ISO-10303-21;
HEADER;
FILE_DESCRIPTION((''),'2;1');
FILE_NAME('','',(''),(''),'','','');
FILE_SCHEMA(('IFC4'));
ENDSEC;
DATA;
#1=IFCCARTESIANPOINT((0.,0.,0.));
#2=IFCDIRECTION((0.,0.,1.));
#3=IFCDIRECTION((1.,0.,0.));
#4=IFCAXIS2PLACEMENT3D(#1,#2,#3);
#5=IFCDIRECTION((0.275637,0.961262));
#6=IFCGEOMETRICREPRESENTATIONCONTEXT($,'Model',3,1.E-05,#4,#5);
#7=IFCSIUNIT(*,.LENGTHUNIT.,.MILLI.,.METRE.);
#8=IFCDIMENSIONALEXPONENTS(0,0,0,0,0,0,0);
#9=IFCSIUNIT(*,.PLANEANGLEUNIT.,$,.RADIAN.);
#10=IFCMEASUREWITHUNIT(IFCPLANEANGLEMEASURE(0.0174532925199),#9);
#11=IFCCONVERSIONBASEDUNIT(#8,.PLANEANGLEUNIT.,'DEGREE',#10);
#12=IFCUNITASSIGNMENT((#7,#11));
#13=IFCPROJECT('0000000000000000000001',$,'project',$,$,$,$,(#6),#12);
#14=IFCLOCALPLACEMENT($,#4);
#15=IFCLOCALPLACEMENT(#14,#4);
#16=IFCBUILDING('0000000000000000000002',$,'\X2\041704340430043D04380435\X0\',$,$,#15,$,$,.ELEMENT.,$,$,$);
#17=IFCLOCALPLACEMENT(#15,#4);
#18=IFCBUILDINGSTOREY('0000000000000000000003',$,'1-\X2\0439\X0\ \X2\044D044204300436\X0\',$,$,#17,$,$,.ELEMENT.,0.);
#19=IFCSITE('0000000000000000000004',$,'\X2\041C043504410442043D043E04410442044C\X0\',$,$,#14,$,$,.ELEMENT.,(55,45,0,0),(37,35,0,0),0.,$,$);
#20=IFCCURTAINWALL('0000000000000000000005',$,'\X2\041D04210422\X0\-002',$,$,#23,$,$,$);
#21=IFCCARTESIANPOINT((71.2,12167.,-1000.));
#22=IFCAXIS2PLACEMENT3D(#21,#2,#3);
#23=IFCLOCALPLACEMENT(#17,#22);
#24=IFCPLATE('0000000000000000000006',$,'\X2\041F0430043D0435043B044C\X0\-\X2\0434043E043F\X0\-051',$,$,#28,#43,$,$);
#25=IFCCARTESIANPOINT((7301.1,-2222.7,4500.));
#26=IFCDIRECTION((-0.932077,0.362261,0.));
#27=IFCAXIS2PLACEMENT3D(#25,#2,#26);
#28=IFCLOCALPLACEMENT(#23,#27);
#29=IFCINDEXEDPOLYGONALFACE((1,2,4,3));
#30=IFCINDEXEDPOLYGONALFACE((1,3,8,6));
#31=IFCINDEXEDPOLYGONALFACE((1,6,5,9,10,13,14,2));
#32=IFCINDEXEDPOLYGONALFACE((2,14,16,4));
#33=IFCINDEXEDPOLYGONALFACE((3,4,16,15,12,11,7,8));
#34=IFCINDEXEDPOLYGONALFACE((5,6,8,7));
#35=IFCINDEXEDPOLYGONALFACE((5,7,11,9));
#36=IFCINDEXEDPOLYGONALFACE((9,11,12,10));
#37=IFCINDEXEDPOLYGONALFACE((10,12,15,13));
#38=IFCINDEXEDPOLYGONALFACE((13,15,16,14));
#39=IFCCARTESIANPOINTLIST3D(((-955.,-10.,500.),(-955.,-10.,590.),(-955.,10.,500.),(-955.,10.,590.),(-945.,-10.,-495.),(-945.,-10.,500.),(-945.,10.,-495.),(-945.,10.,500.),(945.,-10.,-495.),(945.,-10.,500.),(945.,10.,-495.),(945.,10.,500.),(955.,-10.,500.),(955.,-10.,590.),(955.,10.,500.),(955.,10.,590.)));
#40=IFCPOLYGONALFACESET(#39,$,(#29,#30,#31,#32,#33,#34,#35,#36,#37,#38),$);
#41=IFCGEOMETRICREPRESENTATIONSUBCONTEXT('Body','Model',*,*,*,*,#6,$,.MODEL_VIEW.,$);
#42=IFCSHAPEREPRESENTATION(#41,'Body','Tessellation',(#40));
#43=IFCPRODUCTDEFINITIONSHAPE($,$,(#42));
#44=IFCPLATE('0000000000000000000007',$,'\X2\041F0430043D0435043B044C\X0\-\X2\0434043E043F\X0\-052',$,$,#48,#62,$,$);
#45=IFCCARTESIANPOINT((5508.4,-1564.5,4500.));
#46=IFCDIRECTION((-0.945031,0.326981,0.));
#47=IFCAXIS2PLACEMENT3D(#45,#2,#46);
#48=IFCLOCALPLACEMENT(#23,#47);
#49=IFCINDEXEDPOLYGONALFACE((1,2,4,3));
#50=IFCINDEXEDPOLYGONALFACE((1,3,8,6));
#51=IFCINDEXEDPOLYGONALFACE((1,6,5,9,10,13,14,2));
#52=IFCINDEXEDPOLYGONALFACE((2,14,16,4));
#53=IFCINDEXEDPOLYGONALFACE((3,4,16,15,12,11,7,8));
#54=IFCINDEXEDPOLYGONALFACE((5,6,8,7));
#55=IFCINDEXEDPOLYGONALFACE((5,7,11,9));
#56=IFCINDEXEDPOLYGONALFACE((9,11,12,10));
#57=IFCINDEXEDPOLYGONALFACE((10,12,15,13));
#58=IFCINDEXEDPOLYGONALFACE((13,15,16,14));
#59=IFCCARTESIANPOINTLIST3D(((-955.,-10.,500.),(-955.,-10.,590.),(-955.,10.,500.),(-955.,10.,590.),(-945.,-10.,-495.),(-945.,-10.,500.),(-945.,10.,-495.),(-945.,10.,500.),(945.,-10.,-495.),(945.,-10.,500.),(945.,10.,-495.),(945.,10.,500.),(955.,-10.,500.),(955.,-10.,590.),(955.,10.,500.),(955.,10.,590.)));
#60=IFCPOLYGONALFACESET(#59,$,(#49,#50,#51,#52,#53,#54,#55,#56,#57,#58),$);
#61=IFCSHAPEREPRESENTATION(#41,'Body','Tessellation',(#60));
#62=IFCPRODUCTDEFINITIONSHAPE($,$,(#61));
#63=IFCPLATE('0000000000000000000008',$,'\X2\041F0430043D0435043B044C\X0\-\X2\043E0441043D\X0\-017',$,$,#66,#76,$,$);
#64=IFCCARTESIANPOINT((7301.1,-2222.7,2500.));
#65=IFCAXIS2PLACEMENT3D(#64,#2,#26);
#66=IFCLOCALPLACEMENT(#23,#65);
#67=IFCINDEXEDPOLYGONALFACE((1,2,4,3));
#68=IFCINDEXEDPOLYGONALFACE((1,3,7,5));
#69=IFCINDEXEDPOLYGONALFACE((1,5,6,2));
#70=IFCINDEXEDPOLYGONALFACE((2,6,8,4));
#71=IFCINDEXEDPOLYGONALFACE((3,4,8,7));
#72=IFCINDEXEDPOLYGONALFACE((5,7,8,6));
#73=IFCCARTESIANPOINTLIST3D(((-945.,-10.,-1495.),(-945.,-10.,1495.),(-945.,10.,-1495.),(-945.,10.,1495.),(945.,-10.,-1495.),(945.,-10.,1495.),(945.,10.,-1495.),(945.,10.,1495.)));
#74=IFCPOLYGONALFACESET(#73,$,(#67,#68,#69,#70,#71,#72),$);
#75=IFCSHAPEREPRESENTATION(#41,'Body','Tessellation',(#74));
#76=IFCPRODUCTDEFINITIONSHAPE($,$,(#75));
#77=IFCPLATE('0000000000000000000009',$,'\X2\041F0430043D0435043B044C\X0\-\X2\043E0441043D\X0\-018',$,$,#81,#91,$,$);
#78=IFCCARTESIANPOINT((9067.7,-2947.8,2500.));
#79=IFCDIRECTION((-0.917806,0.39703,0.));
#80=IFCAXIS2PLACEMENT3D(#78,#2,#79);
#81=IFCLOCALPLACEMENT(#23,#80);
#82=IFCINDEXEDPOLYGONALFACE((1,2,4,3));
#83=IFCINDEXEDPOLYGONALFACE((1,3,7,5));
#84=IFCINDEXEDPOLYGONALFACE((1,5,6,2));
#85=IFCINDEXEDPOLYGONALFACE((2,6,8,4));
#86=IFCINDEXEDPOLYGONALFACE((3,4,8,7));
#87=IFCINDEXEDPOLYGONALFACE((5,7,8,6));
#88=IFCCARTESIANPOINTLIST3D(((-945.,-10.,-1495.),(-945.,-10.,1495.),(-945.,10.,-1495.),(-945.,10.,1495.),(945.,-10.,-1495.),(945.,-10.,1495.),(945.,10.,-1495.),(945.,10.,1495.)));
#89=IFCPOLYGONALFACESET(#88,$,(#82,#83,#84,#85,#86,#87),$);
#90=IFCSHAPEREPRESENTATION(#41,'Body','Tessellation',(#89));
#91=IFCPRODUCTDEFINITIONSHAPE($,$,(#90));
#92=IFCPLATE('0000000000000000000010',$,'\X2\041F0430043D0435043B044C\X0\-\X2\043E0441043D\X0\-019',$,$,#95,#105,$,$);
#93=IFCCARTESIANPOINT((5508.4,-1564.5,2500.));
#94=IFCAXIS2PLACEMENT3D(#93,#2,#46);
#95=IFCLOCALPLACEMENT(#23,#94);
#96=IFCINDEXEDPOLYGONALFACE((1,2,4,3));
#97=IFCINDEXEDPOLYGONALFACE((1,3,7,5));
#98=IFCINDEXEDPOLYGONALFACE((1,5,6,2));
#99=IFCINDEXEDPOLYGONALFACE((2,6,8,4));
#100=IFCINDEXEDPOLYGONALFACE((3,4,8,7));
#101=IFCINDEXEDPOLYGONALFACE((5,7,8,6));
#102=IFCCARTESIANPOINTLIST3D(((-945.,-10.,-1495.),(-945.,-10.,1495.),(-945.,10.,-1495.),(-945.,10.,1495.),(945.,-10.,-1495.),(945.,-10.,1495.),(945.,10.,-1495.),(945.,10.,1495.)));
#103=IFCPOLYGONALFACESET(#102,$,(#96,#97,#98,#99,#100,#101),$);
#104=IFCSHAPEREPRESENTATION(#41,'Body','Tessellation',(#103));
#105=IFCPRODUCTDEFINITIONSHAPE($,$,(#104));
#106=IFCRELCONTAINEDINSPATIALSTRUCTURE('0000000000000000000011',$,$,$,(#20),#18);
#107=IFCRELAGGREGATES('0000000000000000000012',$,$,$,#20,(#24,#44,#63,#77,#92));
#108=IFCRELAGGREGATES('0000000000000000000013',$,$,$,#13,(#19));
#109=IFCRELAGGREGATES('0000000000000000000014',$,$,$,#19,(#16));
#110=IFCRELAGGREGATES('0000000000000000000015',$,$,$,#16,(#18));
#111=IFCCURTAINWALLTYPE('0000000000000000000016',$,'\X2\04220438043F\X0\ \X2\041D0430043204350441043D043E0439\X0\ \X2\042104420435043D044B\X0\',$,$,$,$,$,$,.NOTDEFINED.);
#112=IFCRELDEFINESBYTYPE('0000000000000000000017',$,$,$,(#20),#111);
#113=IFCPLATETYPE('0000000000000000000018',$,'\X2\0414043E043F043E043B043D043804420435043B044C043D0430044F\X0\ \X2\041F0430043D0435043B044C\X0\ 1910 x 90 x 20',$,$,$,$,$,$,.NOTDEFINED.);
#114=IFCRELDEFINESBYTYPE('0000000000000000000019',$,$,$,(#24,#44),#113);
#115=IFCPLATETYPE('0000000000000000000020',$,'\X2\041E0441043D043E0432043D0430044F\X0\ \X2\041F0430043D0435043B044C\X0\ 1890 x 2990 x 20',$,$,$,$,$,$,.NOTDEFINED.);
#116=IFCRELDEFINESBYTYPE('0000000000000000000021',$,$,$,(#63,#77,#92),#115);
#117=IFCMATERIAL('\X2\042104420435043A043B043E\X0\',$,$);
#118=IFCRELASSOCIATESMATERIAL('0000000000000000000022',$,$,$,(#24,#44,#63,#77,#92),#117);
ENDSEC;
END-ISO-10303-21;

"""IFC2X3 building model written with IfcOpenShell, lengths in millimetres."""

from ifc_helpers import new_model, entity, si_unit, converted_unit, direction, frame, origin_with_axes, place, context, subcontext, project, spatial, polyline, outline, extrude, material, type_object, element, aggregate, save


model = new_model("IFC2X3")

# Units and contexts
model_context = context("Model", 3, precision=1e-05, world=origin_with_axes(), true_north=direction((0.275637, 0.961262)))
body_context = subcontext(model_context, "Body", "Model", "MODEL_VIEW")
ifc_project = project(units=[si_unit("LENGTHUNIT", "METRE", prefix="MILLI"), converted_unit("PLANEANGLEUNIT", "DEGREE", entity("IfcPlaneAngleMeasure", 0.0174532925199), si_unit("PLANEANGLEUNIT", "RADIAN"), dimensions=[0, 0, 0, 0, 0, 0, 0])], contexts=[model_context])

# Site, building, storey
site_placement = place(None, origin_with_axes())
site = spatial("IfcSite", under=ifc_project, at=site_placement, Name="Местность", CompositionType="ELEMENT", RefLatitude=(55, 45, 0, 0), RefLongitude=(37, 35, 0, 0), RefElevation=0.0)
building_placement = place(site_placement, origin_with_axes())
building = spatial("IfcBuilding", under=site, at=building_placement, Name="Здание", CompositionType="ELEMENT")
storey_placement = place(building_placement, origin_with_axes())
storey = spatial("IfcBuildingStorey", under=building, at=storey_placement, Name="1-й этаж", CompositionType="ELEMENT", Elevation=0.0)

# Curtain wall, plates
curtain_wall_type = type_object("IfcCurtainWallType", Name="Тип Навесной Стены", PredefinedType="NOTDEFINED")
curtain_wall_placement = place(storey_placement, frame((71.2, 12167.0, -1000.0), z_axis=(0.0, 0.0, 1.0), x_axis=(1.0, 0.0, 0.0)))
curtain_wall = element("IfcCurtainWall", 1, at=curtain_wall_placement, inside=storey, type_object=curtain_wall_type, Name="НСТ-002")
ifc_material_1 = material(Name="Стекло")
plate_type_1 = type_object("IfcPlateType", Name="Дополнительная Панель 1910 x 90 x 20", PredefinedType="NOTDEFINED")
plate_1_placement = place(curtain_wall_placement, frame((7301.1, -2222.7, 4500.0), z_axis=(0.0, 0.0, 1.0), x_axis=(-0.932077, 0.362261, 0.0)))
plate_1 = element("IfcPlate", 2, at=plate_1_placement, type_object=plate_type_1, material=ifc_material_1, Name="Панель-доп-051", context=body_context, shape_type="SweptSolid", body=[
    extrude(outline(polyline([(-955.0, -590.0), (955.0, -590.0), (955.0, -500.0), (945.0, -500.0), (945.0, 495.0), (-945.0, 495.0), (-945.0, -500.0), (-955.0, -500.0), (-955.0, -590.0)])), frame((0.0, -10.0, 0.0), z_axis=(0.0, 1.0, 0.0), x_axis=(1.0, 0.0, 0.0)), (0.0, 0.0, 1.0), 20.0),
])
plate_2_placement = place(curtain_wall_placement, frame((5508.4, -1564.5, 4500.0), z_axis=(0.0, 0.0, 1.0), x_axis=(-0.945031, 0.326981, 0.0)))
plate_2 = element("IfcPlate", 3, at=plate_2_placement, type_object=plate_type_1, material=ifc_material_1, Name="Панель-доп-052", context=body_context, shape_type="SweptSolid", body=[
    extrude(outline(polyline([(-955.0, -590.0), (955.0, -590.0), (955.0, -500.0), (945.0, -500.0), (945.0, 495.0), (-945.0, 495.0), (-945.0, -500.0), (-955.0, -500.0), (-955.0, -590.0)])), frame((0.0, -10.0, 0.0), z_axis=(0.0, 1.0, 0.0), x_axis=(1.0, 0.0, 0.0)), (0.0, 0.0, 1.0), 20.0),
])
plate_type_2 = type_object("IfcPlateType", Name="Основная Панель 1890 x 2990 x 20", PredefinedType="NOTDEFINED")
plate_3_placement = place(curtain_wall_placement, frame((7301.1, -2222.7, 2500.0), z_axis=(0.0, 0.0, 1.0), x_axis=(-0.932077, 0.362261, 0.0)))
plate_3 = element("IfcPlate", 4, at=plate_3_placement, type_object=plate_type_2, material=ifc_material_1, Name="Панель-осн-017", context=body_context, shape_type="SweptSolid", body=[
    extrude(outline(polyline([(-945.0, -1495.0), (945.0, -1495.0), (945.0, 1495.0), (-945.0, 1495.0), (-945.0, -1495.0)])), frame((0.0, -10.0, 0.0), z_axis=(0.0, 1.0, 0.0), x_axis=(1.0, 0.0, 0.0)), (0.0, 0.0, 1.0), 20.0),
])
plate_4_placement = place(curtain_wall_placement, frame((9067.7, -2947.8, 2500.0), z_axis=(0.0, 0.0, 1.0), x_axis=(-0.917806, 0.39703, 0.0)))
plate_4 = element("IfcPlate", 5, at=plate_4_placement, type_object=plate_type_2, material=ifc_material_1, Name="Панель-осн-018", context=body_context, shape_type="SweptSolid", body=[
    extrude(outline(polyline([(-945.0, -1495.0), (945.0, -1495.0), (945.0, 1495.0), (-945.0, 1495.0), (-945.0, -1495.0)])), frame((0.0, -10.0, 0.0), z_axis=(0.0, 1.0, 0.0), x_axis=(1.0, 0.0, 0.0)), (0.0, 0.0, 1.0), 20.0),
])
plate_5_placement = place(curtain_wall_placement, frame((5508.4, -1564.5, 2500.0), z_axis=(0.0, 0.0, 1.0), x_axis=(-0.945031, 0.326981, 0.0)))
plate_5 = element("IfcPlate", 6, at=plate_5_placement, type_object=plate_type_2, material=ifc_material_1, Name="Панель-осн-019", context=body_context, shape_type="SweptSolid", body=[
    extrude(outline(polyline([(-945.0, -1495.0), (945.0, -1495.0), (945.0, 1495.0), (-945.0, 1495.0), (-945.0, -1495.0)])), frame((0.0, -10.0, 0.0), z_axis=(0.0, 1.0, 0.0), x_axis=(1.0, 0.0, 0.0)), (0.0, 0.0, 1.0), 20.0),
])
aggregate(curtain_wall, [plate_1, plate_2, plate_3, plate_4, plate_5])

save(model, "model.ifc")
